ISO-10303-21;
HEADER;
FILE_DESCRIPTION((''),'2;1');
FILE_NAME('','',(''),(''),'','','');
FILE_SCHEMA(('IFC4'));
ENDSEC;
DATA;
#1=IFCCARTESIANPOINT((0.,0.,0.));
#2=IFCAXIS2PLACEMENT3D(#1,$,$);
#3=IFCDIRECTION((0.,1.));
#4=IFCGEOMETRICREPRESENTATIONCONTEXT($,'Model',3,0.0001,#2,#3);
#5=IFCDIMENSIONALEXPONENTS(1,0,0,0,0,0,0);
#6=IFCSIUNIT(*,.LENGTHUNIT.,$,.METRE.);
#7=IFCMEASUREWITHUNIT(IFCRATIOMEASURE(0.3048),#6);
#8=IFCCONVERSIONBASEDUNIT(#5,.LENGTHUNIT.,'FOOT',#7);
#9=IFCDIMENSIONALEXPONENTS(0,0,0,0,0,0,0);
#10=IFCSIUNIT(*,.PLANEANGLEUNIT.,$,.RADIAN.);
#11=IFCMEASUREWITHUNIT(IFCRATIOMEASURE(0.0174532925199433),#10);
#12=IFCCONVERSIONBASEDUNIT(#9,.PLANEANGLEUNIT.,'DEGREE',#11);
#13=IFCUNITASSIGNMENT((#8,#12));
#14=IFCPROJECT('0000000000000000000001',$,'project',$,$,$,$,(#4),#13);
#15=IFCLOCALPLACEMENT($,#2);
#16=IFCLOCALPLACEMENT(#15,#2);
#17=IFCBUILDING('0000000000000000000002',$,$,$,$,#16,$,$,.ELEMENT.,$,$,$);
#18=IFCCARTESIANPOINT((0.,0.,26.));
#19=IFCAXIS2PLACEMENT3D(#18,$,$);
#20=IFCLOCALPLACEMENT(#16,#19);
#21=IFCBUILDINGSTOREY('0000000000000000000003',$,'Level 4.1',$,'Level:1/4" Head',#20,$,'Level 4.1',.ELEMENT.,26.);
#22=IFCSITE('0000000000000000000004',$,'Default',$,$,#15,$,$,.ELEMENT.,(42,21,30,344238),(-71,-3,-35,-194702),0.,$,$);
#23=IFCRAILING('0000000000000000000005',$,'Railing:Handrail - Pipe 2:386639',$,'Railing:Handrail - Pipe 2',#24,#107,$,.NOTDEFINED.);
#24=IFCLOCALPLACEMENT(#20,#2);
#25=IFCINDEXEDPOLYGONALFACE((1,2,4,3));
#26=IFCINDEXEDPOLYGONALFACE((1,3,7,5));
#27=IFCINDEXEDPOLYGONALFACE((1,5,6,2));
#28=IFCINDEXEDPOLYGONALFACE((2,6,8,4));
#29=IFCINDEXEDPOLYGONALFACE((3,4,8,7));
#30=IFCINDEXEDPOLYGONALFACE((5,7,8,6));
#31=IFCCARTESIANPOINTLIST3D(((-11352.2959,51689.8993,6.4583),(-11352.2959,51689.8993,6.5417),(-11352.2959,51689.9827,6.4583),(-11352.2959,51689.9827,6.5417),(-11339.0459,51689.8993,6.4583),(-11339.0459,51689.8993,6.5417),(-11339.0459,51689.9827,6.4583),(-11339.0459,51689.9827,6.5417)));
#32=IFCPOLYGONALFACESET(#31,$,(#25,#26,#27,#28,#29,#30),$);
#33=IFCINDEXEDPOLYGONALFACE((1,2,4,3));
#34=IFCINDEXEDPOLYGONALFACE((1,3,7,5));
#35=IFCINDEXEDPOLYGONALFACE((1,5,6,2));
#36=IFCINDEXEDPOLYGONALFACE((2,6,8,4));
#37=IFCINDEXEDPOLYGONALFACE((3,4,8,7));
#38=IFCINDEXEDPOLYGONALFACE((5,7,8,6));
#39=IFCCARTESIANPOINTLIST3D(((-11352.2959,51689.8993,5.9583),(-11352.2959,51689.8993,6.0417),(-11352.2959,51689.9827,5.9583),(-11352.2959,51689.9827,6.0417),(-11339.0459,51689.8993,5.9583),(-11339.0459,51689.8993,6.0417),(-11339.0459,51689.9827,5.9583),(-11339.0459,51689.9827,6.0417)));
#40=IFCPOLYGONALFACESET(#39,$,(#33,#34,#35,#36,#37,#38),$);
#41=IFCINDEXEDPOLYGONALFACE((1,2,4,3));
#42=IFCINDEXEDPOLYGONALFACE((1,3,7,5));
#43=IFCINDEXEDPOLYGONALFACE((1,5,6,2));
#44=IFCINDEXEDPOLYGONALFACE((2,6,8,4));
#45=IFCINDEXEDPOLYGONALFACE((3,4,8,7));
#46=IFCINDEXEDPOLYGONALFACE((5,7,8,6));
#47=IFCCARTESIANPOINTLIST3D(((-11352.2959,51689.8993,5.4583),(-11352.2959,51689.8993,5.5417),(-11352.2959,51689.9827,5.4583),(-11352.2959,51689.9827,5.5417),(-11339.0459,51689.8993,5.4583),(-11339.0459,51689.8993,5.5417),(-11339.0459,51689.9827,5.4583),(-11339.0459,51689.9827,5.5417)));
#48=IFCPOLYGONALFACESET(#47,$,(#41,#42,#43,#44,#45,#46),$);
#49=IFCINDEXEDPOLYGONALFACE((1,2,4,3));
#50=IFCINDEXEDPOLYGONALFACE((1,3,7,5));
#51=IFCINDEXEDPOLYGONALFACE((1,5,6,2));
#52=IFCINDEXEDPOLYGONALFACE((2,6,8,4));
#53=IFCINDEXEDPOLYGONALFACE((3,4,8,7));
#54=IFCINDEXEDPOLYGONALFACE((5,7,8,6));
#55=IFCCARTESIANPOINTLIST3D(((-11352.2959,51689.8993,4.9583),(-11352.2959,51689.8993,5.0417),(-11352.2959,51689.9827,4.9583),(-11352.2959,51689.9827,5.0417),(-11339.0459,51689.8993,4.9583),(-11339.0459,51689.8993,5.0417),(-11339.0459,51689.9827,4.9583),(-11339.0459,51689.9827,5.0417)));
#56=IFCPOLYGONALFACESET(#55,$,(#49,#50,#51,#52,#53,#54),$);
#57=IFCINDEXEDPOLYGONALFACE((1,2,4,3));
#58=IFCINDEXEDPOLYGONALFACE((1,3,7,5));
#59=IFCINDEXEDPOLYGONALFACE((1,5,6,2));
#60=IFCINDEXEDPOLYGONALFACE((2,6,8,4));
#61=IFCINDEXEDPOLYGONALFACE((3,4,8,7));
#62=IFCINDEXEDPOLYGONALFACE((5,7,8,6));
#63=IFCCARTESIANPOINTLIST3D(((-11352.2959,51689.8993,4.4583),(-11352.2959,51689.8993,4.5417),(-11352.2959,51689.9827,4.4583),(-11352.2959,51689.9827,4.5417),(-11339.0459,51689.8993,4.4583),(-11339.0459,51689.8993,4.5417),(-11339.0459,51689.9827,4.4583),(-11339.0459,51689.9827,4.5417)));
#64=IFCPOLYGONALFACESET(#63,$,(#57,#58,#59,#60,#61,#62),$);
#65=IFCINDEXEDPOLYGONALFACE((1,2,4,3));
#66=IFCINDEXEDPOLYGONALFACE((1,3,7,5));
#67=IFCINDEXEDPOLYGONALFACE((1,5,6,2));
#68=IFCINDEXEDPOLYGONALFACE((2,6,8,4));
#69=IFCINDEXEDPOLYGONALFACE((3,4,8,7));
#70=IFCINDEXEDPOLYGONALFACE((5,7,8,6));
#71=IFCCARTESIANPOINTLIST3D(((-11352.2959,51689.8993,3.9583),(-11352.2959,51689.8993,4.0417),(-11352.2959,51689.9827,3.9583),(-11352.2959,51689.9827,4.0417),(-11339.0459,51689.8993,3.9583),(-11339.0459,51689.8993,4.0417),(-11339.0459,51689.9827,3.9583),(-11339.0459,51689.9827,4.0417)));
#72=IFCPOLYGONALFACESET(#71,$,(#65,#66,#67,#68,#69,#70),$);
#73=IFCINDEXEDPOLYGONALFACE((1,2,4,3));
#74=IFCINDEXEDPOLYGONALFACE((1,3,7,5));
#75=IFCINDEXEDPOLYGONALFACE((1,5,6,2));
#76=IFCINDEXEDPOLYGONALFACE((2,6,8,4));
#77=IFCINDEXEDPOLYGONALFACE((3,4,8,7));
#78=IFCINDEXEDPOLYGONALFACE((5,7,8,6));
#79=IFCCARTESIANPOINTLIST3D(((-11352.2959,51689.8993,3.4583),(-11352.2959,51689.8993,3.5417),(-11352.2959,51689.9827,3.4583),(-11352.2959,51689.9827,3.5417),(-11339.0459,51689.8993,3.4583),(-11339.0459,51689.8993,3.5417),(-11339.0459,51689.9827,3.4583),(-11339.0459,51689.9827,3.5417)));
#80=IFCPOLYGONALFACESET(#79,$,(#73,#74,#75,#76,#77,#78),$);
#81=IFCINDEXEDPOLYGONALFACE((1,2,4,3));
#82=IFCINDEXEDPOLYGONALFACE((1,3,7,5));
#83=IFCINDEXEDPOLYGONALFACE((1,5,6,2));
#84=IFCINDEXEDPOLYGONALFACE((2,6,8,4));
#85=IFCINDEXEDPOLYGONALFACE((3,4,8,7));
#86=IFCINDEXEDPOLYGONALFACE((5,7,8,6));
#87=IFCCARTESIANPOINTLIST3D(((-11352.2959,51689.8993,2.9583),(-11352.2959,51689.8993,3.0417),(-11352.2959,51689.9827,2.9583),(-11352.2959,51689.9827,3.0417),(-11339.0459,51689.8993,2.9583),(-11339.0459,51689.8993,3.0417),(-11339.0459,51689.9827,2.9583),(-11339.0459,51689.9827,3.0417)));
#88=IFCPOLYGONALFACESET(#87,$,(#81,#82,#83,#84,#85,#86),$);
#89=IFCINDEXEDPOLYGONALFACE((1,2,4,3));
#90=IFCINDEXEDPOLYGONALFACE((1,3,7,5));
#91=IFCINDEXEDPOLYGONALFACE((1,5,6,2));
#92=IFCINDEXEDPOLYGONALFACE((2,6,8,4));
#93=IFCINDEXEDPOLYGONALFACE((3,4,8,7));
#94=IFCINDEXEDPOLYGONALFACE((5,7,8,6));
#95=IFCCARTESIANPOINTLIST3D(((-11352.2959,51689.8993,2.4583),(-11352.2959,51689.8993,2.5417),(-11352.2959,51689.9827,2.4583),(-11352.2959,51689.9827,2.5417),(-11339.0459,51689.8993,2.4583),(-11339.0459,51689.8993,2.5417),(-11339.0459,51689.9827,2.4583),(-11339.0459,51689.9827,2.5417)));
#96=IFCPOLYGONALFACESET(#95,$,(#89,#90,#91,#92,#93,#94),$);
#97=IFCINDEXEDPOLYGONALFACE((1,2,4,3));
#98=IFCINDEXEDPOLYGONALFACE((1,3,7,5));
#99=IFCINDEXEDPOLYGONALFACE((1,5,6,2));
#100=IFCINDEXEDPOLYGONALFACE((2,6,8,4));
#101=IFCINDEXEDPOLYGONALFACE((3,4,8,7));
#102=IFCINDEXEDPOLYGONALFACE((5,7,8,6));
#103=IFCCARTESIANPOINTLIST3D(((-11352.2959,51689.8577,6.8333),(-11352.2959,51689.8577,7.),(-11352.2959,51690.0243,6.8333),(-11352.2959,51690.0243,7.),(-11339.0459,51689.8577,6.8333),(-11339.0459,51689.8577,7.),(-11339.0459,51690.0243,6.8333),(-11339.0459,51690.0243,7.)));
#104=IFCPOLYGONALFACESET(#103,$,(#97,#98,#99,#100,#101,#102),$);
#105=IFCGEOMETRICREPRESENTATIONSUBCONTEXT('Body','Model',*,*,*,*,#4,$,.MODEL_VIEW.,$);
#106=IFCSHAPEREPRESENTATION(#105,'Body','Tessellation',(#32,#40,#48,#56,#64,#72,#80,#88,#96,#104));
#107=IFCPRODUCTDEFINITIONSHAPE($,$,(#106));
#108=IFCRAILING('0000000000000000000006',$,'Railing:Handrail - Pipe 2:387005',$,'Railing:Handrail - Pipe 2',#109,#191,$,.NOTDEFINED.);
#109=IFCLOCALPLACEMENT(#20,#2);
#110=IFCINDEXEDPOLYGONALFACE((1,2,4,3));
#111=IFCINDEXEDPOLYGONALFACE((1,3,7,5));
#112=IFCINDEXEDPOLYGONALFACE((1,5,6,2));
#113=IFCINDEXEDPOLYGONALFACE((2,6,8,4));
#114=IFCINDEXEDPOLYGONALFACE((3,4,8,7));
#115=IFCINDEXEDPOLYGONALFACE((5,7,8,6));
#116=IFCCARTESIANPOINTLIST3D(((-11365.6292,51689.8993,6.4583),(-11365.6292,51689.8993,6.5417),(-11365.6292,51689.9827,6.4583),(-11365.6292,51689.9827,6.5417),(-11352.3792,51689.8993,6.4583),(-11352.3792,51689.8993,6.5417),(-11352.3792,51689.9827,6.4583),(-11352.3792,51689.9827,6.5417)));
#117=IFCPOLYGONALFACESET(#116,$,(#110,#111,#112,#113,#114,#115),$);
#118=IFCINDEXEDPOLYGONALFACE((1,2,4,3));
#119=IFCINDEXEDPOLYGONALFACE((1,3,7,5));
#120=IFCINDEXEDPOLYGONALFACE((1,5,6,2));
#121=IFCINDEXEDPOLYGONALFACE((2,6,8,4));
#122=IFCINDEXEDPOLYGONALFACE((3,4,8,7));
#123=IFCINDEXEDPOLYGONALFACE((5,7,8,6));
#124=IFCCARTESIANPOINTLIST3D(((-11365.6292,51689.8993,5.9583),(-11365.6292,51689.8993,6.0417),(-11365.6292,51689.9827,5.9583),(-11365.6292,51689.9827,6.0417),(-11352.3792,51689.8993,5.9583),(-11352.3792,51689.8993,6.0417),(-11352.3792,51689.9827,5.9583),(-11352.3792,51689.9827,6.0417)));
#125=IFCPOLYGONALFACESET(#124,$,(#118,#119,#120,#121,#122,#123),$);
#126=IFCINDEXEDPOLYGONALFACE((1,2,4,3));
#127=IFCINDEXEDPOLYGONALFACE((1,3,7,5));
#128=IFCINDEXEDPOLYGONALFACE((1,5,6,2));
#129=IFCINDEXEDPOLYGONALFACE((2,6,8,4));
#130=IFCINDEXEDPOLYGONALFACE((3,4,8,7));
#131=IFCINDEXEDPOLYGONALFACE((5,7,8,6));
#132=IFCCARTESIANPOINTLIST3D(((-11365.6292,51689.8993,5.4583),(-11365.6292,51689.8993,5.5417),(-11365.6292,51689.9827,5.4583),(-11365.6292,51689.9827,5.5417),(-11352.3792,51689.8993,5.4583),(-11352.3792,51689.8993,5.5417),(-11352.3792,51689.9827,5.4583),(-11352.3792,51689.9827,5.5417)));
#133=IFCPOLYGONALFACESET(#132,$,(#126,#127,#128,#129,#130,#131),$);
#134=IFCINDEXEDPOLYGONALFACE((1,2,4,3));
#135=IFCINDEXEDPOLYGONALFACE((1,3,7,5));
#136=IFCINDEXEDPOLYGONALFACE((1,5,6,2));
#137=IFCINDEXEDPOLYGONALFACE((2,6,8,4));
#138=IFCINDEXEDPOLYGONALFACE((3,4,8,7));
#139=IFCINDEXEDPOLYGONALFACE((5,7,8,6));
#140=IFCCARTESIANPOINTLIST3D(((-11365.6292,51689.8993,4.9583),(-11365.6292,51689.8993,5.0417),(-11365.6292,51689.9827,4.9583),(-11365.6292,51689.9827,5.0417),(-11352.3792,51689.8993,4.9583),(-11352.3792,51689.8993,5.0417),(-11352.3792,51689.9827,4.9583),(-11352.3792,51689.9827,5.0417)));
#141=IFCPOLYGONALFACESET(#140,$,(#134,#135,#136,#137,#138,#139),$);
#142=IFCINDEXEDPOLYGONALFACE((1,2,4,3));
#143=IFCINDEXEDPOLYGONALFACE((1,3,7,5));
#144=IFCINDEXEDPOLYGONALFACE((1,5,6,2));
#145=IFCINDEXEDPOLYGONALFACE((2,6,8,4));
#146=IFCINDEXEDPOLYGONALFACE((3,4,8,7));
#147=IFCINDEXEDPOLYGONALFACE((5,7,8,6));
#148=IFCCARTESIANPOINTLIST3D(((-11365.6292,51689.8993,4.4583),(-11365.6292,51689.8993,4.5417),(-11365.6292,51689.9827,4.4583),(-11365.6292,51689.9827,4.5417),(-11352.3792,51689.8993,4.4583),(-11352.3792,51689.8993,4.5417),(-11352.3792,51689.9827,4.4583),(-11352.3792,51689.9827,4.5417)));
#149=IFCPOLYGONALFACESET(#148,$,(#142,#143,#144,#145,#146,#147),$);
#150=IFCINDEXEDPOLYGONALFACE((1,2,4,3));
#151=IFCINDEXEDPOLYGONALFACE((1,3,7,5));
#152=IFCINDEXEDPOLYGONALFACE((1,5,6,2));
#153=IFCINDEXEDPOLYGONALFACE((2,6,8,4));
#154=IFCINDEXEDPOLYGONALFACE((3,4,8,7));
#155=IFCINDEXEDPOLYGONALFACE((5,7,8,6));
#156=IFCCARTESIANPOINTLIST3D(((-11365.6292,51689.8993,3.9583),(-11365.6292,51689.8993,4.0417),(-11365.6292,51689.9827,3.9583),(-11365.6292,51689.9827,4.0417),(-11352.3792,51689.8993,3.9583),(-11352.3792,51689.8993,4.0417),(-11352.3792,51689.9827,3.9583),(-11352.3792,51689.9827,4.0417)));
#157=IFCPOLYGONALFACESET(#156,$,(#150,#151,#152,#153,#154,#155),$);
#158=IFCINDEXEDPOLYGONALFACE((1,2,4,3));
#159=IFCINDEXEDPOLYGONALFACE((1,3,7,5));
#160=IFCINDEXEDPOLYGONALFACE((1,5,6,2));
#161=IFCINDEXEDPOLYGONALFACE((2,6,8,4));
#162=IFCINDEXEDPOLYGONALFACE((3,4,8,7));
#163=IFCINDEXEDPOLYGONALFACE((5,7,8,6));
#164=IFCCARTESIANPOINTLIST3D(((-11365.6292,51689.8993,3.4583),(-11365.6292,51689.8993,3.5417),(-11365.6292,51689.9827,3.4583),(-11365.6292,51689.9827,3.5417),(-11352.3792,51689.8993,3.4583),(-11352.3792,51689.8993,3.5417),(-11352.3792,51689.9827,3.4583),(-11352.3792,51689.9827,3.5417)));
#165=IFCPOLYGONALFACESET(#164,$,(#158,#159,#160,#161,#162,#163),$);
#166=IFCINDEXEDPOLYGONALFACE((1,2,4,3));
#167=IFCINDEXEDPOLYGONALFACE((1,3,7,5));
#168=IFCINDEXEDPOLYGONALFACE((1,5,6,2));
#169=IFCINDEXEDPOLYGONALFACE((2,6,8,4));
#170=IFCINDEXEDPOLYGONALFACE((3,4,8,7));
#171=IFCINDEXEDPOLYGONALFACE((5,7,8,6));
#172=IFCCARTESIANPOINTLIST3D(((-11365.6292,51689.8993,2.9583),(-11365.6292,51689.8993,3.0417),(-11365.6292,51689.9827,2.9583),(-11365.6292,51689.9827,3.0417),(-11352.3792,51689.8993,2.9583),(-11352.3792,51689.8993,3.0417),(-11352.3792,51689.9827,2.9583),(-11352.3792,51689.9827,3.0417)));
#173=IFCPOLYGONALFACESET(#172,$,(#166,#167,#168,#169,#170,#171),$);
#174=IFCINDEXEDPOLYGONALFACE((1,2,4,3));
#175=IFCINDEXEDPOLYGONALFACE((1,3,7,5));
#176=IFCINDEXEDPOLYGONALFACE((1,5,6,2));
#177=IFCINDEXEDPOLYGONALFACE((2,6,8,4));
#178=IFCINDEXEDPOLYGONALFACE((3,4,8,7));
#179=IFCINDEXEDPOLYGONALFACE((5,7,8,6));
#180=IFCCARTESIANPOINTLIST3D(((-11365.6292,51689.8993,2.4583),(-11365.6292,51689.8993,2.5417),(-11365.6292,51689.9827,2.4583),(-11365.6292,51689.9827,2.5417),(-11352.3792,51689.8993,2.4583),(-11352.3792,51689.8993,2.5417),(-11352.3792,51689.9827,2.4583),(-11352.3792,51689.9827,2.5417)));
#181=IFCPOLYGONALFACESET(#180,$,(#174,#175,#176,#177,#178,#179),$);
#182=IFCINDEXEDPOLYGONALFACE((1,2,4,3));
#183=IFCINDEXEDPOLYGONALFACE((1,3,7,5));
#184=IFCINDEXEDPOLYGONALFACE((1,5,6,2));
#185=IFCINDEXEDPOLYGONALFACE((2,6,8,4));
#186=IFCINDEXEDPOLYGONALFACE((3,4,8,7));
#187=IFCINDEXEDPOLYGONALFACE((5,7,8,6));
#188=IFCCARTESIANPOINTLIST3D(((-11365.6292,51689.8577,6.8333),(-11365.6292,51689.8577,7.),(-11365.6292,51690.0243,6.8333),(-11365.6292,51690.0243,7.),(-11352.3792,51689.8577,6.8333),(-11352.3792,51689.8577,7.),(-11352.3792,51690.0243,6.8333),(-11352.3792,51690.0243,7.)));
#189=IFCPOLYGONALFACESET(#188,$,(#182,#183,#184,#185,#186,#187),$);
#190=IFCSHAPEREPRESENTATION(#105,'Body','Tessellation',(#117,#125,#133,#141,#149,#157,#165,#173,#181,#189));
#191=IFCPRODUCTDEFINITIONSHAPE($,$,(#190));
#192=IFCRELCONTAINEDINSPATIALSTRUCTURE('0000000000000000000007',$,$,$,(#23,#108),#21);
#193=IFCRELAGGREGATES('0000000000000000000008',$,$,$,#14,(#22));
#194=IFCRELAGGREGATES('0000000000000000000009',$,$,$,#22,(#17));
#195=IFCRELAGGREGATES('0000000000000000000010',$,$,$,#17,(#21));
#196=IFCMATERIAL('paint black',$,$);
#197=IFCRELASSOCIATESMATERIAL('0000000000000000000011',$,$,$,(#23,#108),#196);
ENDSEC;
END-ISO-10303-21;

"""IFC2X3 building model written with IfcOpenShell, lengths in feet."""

from ifc_helpers import new_model, entity, si_unit, converted_unit, direction, frame, frame_2d, origin, place, context, subcontext, project, spatial, rectangle, extrude, material, element, save


model = new_model("IFC2X3")

# Units and contexts
model_context = context("Model", 3, precision=0.0001, world=origin(), true_north=direction((0.0, 1.0)))
body_context = subcontext(model_context, "Body", "Model", "MODEL_VIEW")
ifc_project = project(units=[converted_unit("LENGTHUNIT", "FOOT", entity("IfcRatioMeasure", 0.3048), si_unit("LENGTHUNIT", "METRE"), dimensions=[1, 0, 0, 0, 0, 0, 0]), converted_unit("PLANEANGLEUNIT", "DEGREE", entity("IfcRatioMeasure", 0.0174532925199433), si_unit("PLANEANGLEUNIT", "RADIAN"), dimensions=[0, 0, 0, 0, 0, 0, 0])], contexts=[model_context])

# Site, building, storey
site_placement = place(None, origin())
site = spatial("IfcSite", under=ifc_project, at=site_placement, Name="Default", CompositionType="ELEMENT", RefLatitude=(42, 21, 30, 344238), RefLongitude=(-71, -3, -35, -194702), RefElevation=0.0)
building_placement = place(site_placement, origin())
building = spatial("IfcBuilding", under=site, at=building_placement, CompositionType="ELEMENT")
storey_placement = place(building_placement, frame((0.0, 0.0, 26.0)))
storey = spatial("IfcBuildingStorey", under=building, at=storey_placement, Name="Level 4.1", ObjectType="Level:1/4\" Head", LongName="Level 4.1", CompositionType="ELEMENT", Elevation=26.0)

# Railings
ifc_material_1 = material(Name="paint black")
railing_1_placement = place(storey_placement, origin())
element("IfcRailing", 1, at=railing_1_placement, inside=storey, material=ifc_material_1, Name="Railing:Handrail - Pipe 2:386639", ObjectType="Railing:Handrail - Pipe 2", PredefinedType="NOTDEFINED", context=body_context, shape_type="SweptSolid", body=[
    extrude(rectangle(XDim=13.25, YDim=0.0833, at=frame_2d((0.0, 0.0), x_axis=(1.0, 0.0))), frame((-11345.6709, 51689.941, 6.4583), z_axis=(0.0, 0.0, 1.0), x_axis=(-1.0, 0.0, 0.0)), (0.0, 0.0, 1.0), 0.0833),
    extrude(rectangle(XDim=13.25, YDim=0.0833, at=frame_2d((0.0, 0.0), x_axis=(1.0, 0.0))), frame((-11345.6709, 51689.941, 5.9583), z_axis=(0.0, 0.0, 1.0), x_axis=(-1.0, 0.0, 0.0)), (0.0, 0.0, 1.0), 0.0833),
    extrude(rectangle(XDim=13.25, YDim=0.0833, at=frame_2d((0.0, 0.0), x_axis=(1.0, 0.0))), frame((-11345.6709, 51689.941, 5.4583), z_axis=(0.0, 0.0, 1.0), x_axis=(-1.0, 0.0, 0.0)), (0.0, 0.0, 1.0), 0.0833),
    extrude(rectangle(XDim=13.25, YDim=0.0833, at=frame_2d((0.0, 0.0), x_axis=(1.0, 0.0))), frame((-11345.6709, 51689.941, 4.9583), z_axis=(0.0, 0.0, 1.0), x_axis=(-1.0, 0.0, 0.0)), (0.0, 0.0, 1.0), 0.0833),
    extrude(rectangle(XDim=13.25, YDim=0.0833, at=frame_2d((0.0, 0.0), x_axis=(1.0, 0.0))), frame((-11345.6709, 51689.941, 4.4583), z_axis=(0.0, 0.0, 1.0), x_axis=(-1.0, 0.0, 0.0)), (0.0, 0.0, 1.0), 0.0833),
    extrude(rectangle(XDim=13.25, YDim=0.0833, at=frame_2d((0.0, 0.0), x_axis=(1.0, 0.0))), frame((-11345.6709, 51689.941, 3.9583), z_axis=(0.0, 0.0, 1.0), x_axis=(-1.0, 0.0, 0.0)), (0.0, 0.0, 1.0), 0.0833),
    extrude(rectangle(XDim=13.25, YDim=0.0833, at=frame_2d((0.0, 0.0), x_axis=(1.0, 0.0))), frame((-11345.6709, 51689.941, 3.4583), z_axis=(0.0, 0.0, 1.0), x_axis=(-1.0, 0.0, 0.0)), (0.0, 0.0, 1.0), 0.0833),
    extrude(rectangle(XDim=13.25, YDim=0.0833, at=frame_2d((0.0, 0.0), x_axis=(1.0, 0.0))), frame((-11345.6709, 51689.941, 2.9583), z_axis=(0.0, 0.0, 1.0), x_axis=(-1.0, 0.0, 0.0)), (0.0, 0.0, 1.0), 0.0833),
    extrude(rectangle(XDim=13.25, YDim=0.0833, at=frame_2d((0.0, 0.0), x_axis=(1.0, 0.0))), frame((-11345.6709, 51689.941, 2.4583), z_axis=(0.0, 0.0, 1.0), x_axis=(-1.0, 0.0, 0.0)), (0.0, 0.0, 1.0), 0.0833),
    extrude(rectangle(XDim=13.25, YDim=0.1667, at=frame_2d((0.0, 0.0), x_axis=(1.0, 0.0))), frame((-11345.6709, 51689.941, 6.8333), z_axis=(0.0, 0.0, 1.0), x_axis=(-1.0, 0.0, 0.0)), (0.0, 0.0, 1.0), 0.1667),
])
railing_2_placement = place(storey_placement, origin())
element("IfcRailing", 2, at=railing_2_placement, inside=storey, material=ifc_material_1, Name="Railing:Handrail - Pipe 2:387005", ObjectType="Railing:Handrail - Pipe 2", PredefinedType="NOTDEFINED", context=body_context, shape_type="SweptSolid", body=[
    extrude(rectangle(XDim=13.25, YDim=0.0833, at=frame_2d((0.0, 0.0), x_axis=(1.0, 0.0))), frame((-11359.0042, 51689.941, 6.4583), z_axis=(0.0, 0.0, 1.0), x_axis=(-1.0, 0.0, 0.0)), (0.0, 0.0, 1.0), 0.0833),
    extrude(rectangle(XDim=13.25, YDim=0.0833, at=frame_2d((0.0, 0.0), x_axis=(1.0, 0.0))), frame((-11359.0042, 51689.941, 5.9583), z_axis=(0.0, 0.0, 1.0), x_axis=(-1.0, 0.0, 0.0)), (0.0, 0.0, 1.0), 0.0833),
    extrude(rectangle(XDim=13.25, YDim=0.0833, at=frame_2d((0.0, 0.0), x_axis=(1.0, 0.0))), frame((-11359.0042, 51689.941, 5.4583), z_axis=(0.0, 0.0, 1.0), x_axis=(-1.0, 0.0, 0.0)), (0.0, 0.0, 1.0), 0.0833),
    extrude(rectangle(XDim=13.25, YDim=0.0833, at=frame_2d((0.0, 0.0), x_axis=(1.0, 0.0))), frame((-11359.0042, 51689.941, 4.9583), z_axis=(0.0, 0.0, 1.0), x_axis=(-1.0, 0.0, 0.0)), (0.0, 0.0, 1.0), 0.0833),
    extrude(rectangle(XDim=13.25, YDim=0.0833, at=frame_2d((0.0, 0.0), x_axis=(1.0, 0.0))), frame((-11359.0042, 51689.941, 4.4583), z_axis=(0.0, 0.0, 1.0), x_axis=(-1.0, 0.0, 0.0)), (0.0, 0.0, 1.0), 0.0833),
    extrude(rectangle(XDim=13.25, YDim=0.0833, at=frame_2d((0.0, 0.0), x_axis=(1.0, 0.0))), frame((-11359.0042, 51689.941, 3.9583), z_axis=(0.0, 0.0, 1.0), x_axis=(-1.0, 0.0, 0.0)), (0.0, 0.0, 1.0), 0.0833),
    extrude(rectangle(XDim=13.25, YDim=0.0833, at=frame_2d((0.0, 0.0), x_axis=(1.0, 0.0))), frame((-11359.0042, 51689.941, 3.4583), z_axis=(0.0, 0.0, 1.0), x_axis=(-1.0, 0.0, 0.0)), (0.0, 0.0, 1.0), 0.0833),
    extrude(rectangle(XDim=13.25, YDim=0.0833, at=frame_2d((0.0, 0.0), x_axis=(1.0, 0.0))), frame((-11359.0042, 51689.941, 2.9583), z_axis=(0.0, 0.0, 1.0), x_axis=(-1.0, 0.0, 0.0)), (0.0, 0.0, 1.0), 0.0833),
    extrude(rectangle(XDim=13.25, YDim=0.0833, at=frame_2d((0.0, 0.0), x_axis=(1.0, 0.0))), frame((-11359.0042, 51689.941, 2.4583), z_axis=(0.0, 0.0, 1.0), x_axis=(-1.0, 0.0, 0.0)), (0.0, 0.0, 1.0), 0.0833),
    extrude(rectangle(XDim=13.25, YDim=0.1667, at=frame_2d((0.0, 0.0), x_axis=(1.0, 0.0))), frame((-11359.0042, 51689.941, 6.8333), z_axis=(0.0, 0.0, 1.0), x_axis=(-1.0, 0.0, 0.0)), (0.0, 0.0, 1.0), 0.1667),
])

save(model, "model.ifc")
